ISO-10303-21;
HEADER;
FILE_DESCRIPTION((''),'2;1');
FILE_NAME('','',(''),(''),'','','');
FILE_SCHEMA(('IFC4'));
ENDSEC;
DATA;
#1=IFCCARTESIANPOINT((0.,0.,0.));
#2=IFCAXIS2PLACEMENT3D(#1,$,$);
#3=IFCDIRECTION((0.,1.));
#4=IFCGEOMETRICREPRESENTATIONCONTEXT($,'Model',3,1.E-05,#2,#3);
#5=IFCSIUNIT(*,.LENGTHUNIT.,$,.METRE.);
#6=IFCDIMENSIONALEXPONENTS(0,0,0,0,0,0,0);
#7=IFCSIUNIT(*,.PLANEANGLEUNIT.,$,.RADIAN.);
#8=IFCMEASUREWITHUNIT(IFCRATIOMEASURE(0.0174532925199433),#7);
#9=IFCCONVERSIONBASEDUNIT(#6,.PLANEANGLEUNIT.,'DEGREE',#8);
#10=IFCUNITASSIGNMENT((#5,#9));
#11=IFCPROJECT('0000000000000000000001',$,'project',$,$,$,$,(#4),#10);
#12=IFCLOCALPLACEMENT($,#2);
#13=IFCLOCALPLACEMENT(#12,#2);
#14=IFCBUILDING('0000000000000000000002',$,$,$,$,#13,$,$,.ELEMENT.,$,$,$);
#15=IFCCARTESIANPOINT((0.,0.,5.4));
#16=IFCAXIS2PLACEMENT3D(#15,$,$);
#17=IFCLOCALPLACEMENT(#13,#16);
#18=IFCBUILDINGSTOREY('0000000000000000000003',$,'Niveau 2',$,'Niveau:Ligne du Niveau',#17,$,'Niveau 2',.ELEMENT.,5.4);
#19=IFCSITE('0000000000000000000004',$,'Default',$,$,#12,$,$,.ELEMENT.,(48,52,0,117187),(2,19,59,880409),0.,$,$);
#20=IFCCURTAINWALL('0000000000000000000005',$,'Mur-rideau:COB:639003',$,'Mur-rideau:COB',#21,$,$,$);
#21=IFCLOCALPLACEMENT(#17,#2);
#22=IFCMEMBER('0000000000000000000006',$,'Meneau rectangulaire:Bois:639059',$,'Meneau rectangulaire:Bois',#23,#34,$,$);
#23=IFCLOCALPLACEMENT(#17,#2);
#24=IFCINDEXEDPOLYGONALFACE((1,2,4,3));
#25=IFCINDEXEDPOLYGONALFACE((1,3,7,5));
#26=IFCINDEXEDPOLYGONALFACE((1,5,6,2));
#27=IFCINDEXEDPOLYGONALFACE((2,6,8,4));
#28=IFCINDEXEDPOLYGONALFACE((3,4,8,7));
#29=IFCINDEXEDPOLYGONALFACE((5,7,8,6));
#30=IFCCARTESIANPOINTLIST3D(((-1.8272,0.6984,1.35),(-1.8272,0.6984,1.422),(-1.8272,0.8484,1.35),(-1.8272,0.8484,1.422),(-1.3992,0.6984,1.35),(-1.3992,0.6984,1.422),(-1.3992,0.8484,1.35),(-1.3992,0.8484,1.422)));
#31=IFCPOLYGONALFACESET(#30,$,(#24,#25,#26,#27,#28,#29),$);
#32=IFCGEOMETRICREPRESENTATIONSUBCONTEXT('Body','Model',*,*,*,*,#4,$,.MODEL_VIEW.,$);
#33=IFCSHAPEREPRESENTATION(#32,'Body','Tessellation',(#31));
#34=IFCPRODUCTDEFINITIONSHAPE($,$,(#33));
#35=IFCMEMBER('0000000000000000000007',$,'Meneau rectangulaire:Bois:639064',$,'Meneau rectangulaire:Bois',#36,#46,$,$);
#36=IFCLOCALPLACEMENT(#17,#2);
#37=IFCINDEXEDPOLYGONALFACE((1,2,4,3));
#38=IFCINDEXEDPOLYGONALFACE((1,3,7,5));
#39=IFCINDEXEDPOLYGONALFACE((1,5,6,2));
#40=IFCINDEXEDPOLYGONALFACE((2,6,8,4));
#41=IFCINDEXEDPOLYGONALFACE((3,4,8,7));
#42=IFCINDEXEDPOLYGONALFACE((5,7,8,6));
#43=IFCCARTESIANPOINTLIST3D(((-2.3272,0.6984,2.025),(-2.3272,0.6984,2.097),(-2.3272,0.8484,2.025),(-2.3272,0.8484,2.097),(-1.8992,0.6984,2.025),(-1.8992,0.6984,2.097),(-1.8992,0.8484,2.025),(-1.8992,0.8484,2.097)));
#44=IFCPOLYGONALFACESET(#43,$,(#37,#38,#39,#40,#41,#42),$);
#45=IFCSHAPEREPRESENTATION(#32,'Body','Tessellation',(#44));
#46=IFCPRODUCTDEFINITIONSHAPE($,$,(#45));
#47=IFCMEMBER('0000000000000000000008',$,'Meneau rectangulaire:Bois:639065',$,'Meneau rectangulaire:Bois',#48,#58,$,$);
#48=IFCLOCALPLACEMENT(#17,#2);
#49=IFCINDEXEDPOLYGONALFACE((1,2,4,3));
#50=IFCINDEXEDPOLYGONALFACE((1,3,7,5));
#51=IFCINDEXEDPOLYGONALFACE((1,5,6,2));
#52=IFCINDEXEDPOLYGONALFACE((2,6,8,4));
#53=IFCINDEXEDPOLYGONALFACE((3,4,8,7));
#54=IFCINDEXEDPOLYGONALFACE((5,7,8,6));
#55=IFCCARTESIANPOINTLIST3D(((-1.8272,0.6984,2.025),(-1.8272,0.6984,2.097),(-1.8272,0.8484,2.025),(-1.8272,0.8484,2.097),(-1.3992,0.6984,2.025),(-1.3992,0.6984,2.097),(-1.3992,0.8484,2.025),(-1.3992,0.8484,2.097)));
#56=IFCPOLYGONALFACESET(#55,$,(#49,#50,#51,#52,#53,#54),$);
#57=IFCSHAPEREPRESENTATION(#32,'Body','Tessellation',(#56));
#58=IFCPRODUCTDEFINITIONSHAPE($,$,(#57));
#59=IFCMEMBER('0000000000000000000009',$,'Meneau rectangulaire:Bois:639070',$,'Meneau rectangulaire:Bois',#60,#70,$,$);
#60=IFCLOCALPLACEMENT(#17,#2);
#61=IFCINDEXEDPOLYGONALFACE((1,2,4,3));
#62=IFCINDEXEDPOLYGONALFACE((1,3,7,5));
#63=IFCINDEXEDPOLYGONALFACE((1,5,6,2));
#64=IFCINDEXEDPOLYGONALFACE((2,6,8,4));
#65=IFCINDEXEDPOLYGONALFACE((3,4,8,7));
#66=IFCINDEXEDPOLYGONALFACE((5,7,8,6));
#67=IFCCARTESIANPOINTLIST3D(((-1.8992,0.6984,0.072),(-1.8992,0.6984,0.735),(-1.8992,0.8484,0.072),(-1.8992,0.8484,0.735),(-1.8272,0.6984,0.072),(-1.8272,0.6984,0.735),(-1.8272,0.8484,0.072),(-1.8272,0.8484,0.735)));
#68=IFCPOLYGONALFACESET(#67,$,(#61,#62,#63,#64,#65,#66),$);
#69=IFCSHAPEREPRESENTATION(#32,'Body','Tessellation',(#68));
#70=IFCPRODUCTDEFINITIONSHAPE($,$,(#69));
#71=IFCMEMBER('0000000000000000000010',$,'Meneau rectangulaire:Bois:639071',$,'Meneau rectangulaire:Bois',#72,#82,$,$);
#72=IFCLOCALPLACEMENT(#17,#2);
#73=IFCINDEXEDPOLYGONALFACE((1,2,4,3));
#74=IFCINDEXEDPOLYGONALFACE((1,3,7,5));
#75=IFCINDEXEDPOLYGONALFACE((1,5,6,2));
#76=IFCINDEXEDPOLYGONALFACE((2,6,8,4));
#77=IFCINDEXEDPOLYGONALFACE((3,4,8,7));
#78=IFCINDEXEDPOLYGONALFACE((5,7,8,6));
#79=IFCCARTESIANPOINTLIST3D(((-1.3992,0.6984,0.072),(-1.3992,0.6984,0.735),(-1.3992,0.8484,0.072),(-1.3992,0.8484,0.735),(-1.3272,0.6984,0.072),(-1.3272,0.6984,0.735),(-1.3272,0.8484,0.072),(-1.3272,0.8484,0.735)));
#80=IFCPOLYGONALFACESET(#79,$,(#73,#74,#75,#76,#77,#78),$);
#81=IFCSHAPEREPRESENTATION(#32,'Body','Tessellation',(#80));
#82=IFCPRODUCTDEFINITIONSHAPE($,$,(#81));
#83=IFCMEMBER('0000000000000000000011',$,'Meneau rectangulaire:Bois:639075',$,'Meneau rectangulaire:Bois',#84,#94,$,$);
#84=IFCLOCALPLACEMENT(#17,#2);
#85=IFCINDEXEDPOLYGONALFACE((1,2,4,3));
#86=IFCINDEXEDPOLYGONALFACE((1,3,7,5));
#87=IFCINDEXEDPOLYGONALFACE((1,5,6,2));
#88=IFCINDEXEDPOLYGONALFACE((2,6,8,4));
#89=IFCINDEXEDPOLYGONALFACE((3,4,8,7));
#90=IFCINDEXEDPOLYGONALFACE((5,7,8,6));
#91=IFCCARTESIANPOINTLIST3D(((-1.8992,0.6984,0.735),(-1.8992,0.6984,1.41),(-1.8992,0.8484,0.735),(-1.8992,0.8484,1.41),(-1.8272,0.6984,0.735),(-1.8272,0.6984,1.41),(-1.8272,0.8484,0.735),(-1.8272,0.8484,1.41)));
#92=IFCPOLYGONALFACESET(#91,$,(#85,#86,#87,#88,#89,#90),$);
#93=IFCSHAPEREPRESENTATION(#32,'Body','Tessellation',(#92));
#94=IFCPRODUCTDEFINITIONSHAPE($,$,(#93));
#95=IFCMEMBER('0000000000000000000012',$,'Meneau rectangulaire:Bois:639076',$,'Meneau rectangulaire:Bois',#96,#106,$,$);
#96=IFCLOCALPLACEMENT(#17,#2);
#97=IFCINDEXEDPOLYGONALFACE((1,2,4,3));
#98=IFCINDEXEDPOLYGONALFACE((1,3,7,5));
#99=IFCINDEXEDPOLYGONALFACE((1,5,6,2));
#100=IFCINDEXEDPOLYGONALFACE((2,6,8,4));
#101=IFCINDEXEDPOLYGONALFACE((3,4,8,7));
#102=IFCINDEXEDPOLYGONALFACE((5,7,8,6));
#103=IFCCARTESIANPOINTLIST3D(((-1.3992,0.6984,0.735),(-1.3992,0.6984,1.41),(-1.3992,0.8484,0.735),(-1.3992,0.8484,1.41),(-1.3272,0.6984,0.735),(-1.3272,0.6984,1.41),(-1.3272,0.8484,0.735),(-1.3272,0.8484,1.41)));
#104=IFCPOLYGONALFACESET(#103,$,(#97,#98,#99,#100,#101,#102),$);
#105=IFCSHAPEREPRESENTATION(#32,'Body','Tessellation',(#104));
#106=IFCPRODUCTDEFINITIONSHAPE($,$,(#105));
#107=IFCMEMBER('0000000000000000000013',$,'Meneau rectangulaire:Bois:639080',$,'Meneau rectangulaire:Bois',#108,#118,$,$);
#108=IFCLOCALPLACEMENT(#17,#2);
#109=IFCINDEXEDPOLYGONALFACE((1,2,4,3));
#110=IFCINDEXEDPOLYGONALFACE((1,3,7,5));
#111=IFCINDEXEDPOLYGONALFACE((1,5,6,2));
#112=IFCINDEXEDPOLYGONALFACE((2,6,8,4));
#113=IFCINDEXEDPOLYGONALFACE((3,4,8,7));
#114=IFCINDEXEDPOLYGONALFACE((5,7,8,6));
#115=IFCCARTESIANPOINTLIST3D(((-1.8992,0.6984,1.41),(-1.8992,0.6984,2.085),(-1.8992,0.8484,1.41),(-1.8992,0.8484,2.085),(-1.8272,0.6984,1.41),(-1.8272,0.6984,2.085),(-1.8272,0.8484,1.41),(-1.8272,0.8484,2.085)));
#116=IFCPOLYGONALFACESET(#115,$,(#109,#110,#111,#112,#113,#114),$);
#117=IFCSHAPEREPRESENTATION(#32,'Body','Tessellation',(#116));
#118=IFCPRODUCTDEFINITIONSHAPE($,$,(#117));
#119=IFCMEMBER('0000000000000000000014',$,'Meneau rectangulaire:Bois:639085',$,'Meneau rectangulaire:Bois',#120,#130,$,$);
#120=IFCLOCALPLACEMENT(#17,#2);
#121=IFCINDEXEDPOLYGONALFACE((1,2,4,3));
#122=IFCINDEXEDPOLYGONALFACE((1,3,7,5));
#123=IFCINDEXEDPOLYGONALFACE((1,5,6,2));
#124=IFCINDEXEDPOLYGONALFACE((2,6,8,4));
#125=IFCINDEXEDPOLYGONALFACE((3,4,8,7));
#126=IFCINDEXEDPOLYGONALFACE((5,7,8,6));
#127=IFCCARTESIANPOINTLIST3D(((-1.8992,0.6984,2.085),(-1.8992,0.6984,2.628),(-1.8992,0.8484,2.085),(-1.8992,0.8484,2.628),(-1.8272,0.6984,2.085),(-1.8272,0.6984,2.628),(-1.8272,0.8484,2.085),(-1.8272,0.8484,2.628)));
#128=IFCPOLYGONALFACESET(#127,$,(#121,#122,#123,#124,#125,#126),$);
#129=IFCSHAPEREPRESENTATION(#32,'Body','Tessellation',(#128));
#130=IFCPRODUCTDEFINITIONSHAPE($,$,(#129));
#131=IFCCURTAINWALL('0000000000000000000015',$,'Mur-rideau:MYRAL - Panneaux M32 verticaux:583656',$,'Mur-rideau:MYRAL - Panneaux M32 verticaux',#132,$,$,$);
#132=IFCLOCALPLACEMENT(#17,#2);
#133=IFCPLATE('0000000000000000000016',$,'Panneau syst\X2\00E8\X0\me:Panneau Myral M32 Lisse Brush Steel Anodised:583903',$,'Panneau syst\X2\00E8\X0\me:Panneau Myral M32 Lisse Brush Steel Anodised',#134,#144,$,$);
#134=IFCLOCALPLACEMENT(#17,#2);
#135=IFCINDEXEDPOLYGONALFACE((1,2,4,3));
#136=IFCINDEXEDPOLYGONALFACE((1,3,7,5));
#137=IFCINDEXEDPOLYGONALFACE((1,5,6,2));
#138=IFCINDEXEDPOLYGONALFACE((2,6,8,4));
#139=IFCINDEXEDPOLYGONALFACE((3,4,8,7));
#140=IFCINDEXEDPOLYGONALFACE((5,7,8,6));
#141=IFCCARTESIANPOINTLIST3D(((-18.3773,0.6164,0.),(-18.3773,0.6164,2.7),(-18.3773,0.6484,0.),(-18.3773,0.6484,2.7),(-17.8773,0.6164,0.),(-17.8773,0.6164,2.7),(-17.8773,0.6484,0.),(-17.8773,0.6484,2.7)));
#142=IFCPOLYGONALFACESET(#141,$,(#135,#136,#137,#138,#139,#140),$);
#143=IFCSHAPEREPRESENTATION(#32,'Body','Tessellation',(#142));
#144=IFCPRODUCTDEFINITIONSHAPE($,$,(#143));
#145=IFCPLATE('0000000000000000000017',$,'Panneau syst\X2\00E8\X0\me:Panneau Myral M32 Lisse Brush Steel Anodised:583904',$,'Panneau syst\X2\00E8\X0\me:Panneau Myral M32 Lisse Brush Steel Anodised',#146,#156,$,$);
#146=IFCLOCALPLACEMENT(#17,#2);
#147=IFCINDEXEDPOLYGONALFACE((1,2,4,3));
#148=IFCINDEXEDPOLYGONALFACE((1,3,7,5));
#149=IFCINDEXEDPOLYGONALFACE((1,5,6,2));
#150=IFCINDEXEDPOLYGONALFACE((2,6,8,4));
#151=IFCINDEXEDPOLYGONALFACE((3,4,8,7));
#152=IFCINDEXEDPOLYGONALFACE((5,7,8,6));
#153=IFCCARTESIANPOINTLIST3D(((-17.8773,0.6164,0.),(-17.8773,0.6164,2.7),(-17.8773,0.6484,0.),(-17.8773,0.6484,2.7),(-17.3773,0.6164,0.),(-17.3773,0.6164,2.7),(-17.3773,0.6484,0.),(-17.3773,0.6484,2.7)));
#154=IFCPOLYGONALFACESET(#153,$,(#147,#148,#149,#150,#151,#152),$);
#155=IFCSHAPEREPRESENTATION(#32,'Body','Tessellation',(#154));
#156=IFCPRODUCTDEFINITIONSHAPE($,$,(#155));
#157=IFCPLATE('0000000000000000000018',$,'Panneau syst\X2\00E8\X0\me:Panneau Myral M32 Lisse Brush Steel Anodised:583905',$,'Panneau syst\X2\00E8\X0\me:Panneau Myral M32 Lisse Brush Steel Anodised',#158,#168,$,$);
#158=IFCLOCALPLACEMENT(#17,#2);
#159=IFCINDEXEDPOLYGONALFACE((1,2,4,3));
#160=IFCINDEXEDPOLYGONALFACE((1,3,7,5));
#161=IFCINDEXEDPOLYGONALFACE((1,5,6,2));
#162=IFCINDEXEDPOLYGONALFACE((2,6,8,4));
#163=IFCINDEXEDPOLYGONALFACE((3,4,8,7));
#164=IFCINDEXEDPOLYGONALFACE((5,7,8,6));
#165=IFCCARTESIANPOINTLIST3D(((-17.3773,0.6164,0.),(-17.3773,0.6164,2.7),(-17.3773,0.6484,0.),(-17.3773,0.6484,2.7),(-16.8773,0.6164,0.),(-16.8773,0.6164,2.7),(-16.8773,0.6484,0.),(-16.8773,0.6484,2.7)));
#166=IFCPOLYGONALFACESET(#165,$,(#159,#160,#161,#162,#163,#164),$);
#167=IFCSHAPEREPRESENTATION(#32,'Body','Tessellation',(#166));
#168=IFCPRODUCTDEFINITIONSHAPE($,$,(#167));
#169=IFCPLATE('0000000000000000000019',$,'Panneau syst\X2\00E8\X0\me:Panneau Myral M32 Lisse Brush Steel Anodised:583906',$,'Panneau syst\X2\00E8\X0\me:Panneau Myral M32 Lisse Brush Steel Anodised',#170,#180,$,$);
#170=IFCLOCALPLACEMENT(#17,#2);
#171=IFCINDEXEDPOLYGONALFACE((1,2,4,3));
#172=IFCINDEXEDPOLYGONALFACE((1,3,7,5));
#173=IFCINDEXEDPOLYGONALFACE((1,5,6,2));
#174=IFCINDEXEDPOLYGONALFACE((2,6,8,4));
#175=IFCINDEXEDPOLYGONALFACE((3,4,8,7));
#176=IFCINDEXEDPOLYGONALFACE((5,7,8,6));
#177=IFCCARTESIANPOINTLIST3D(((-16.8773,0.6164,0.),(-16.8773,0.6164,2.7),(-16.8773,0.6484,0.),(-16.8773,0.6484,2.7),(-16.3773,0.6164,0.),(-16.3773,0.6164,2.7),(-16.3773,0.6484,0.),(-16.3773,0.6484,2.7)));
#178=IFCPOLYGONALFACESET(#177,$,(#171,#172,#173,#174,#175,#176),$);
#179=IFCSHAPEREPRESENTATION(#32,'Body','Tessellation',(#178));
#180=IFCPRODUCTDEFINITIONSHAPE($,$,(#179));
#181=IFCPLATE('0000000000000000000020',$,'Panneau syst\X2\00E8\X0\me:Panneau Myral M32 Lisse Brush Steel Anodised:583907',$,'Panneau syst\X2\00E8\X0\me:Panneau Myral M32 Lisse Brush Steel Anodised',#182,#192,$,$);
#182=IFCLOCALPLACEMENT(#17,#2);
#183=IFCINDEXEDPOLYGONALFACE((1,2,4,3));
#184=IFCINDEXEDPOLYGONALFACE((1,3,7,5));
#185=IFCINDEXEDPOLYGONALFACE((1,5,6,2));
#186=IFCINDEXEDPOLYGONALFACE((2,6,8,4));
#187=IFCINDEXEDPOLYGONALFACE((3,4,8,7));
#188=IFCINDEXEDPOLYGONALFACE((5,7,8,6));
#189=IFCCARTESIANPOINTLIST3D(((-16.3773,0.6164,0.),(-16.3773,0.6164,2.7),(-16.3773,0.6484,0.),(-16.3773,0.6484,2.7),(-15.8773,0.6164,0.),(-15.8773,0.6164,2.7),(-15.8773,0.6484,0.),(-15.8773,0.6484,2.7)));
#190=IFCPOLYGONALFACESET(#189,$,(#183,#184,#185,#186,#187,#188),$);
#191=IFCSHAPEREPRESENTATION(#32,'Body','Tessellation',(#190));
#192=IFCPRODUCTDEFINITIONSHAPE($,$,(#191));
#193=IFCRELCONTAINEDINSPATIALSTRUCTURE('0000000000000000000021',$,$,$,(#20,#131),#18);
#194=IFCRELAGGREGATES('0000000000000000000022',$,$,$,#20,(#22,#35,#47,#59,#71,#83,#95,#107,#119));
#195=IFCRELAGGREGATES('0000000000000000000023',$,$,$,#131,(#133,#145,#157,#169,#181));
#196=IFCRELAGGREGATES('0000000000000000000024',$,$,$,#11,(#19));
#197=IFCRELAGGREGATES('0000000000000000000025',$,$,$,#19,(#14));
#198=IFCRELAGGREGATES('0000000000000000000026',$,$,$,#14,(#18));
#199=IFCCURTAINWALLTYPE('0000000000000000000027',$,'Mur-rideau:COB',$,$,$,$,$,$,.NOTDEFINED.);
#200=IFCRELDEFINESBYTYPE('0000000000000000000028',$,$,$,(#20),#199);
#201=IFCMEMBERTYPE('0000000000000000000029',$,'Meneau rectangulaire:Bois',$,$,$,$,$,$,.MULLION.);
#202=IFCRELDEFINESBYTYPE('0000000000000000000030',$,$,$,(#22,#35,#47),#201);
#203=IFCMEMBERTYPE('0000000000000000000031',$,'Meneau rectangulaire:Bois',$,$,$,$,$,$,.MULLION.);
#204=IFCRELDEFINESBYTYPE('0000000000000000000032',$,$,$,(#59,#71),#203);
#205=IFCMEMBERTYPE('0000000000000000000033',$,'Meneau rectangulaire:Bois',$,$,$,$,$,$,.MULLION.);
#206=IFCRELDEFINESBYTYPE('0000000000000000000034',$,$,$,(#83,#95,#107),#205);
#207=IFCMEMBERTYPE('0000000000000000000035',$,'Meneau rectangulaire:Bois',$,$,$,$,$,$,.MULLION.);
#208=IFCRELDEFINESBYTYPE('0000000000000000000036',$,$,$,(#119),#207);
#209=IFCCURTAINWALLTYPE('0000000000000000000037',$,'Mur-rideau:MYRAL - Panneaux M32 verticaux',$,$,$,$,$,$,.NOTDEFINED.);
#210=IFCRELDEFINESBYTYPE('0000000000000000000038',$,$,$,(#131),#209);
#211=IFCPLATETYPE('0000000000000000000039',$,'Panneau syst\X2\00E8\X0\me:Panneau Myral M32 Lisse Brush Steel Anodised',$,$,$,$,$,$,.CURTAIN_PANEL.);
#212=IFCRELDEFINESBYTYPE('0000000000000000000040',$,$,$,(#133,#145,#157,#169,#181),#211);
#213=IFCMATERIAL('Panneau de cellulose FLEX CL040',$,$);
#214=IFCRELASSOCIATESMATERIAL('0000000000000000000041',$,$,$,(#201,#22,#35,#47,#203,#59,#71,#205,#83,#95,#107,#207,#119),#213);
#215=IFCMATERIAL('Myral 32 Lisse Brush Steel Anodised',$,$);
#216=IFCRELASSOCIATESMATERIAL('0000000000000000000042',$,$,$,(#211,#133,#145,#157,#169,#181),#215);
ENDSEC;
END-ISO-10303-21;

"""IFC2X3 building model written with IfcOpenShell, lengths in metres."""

from ifc_helpers import new_model, entity, si_unit, converted_unit, direction, frame, origin, origin_2d_with_axis, place, context, subcontext, project, spatial, rectangle, extrude, source, transform, mapped, material, type_object, type_shapes, element, aggregate, save


model = new_model("IFC2X3")

# Units and contexts
model_context = context("Model", 3, precision=1e-05, world=origin(), true_north=direction((0.0, 1.0)))
body_context = subcontext(model_context, "Body", "Model", "MODEL_VIEW")
ifc_project = project(units=[si_unit("LENGTHUNIT", "METRE"), converted_unit("PLANEANGLEUNIT", "DEGREE", entity("IfcRatioMeasure", 0.0174532925199433), si_unit("PLANEANGLEUNIT", "RADIAN"), dimensions=[0, 0, 0, 0, 0, 0, 0])], contexts=[model_context])

# Site, building, storey
site_placement = place(None, origin())
site = spatial("IfcSite", under=ifc_project, at=site_placement, Name="Default", CompositionType="ELEMENT", RefLatitude=(48, 52, 0, 117187), RefLongitude=(2, 19, 59, 880409), RefElevation=0.0)
building_placement = place(site_placement, origin())
building = spatial("IfcBuilding", under=site, at=building_placement, CompositionType="ELEMENT")
storey_placement = place(building_placement, frame((0.0, 0.0, 5.4)))
storey = spatial("IfcBuildingStorey", under=building, at=storey_placement, Name="Niveau 2", ObjectType="Niveau:Ligne du Niveau", LongName="Niveau 2", CompositionType="ELEMENT", Elevation=5.4)

# Curtain wall, members
curtain_wall_type_1 = type_object("IfcCurtainWallType", Name="Mur-rideau:COB", PredefinedType="NOTDEFINED")
curtain_wall_1_placement = place(storey_placement, frame((0.0, 0.0, -5.4)))
curtain_wall_1 = element("IfcCurtainWall", 1, at=curtain_wall_1_placement, inside=storey, type_object=curtain_wall_type_1, Name="Mur-rideau:COB:639003", ObjectType="Mur-rideau:COB")
ifc_material_1 = material(Name="Panneau de cellulose FLEX CL040")
member_type_1 = type_object("IfcMemberType", Name="Meneau rectangulaire:Bois", PredefinedType="MULLION", material=ifc_material_1)
shared_shape_1 = source(origin(), body_context, "Body", "SweptSolid", [
    extrude(rectangle(XDim=0.15, YDim=0.072, at=origin_2d_with_axis()), frame((-0.024, 0.0, -0.428), z_axis=(0.0, 0.0, 1.0), x_axis=(0.0, -1.0, 0.0)), (0.0, 0.0, 1.0), 0.428),
])
type_shapes(member_type_1, [shared_shape_1])
member_1_placement = place(storey_placement, frame((-1.3992, 0.7734, 1.41), z_axis=(1.0, 0.0, 0.0), x_axis=(0.0, 0.0, 1.0)))
member_1 = element("IfcMember", 2, at=member_1_placement, type_object=member_type_1, material=ifc_material_1, Name="Meneau rectangulaire:Bois:639059", ObjectType="Meneau rectangulaire:Bois", context=body_context, shape_type="MappedRepresentation", body=[
    mapped(shared_shape_1, transform((0.0, 0.0, 0.0), scale=1.0)),
])
member_2_placement = place(storey_placement, frame((-1.8992, 0.7734, 2.085), z_axis=(1.0, 0.0, 0.0), x_axis=(0.0, 0.0, 1.0)))
member_2 = element("IfcMember", 3, at=member_2_placement, type_object=member_type_1, material=ifc_material_1, Name="Meneau rectangulaire:Bois:639064", ObjectType="Meneau rectangulaire:Bois", context=body_context, shape_type="MappedRepresentation", body=[
    mapped(shared_shape_1, transform((0.0, 0.0, 0.0), scale=1.0)),
])
member_3_placement = place(storey_placement, frame((-1.3992, 0.7734, 2.085), z_axis=(1.0, 0.0, 0.0), x_axis=(0.0, 0.0, 1.0)))
member_3 = element("IfcMember", 4, at=member_3_placement, type_object=member_type_1, material=ifc_material_1, Name="Meneau rectangulaire:Bois:639065", ObjectType="Meneau rectangulaire:Bois", context=body_context, shape_type="MappedRepresentation", body=[
    mapped(shared_shape_1, transform((0.0, 0.0, 0.0), scale=1.0)),
])
member_type_2 = type_object("IfcMemberType", Name="Meneau rectangulaire:Bois", PredefinedType="MULLION", material=ifc_material_1)
shared_shape_2 = source(origin(), body_context, "Body", "SweptSolid", [
    extrude(rectangle(XDim=0.15, YDim=0.072, at=origin_2d_with_axis()), frame((-0.024, 0.0, -0.663), z_axis=(0.0, 0.0, 1.0), x_axis=(0.0, -1.0, 0.0)), (0.0, 0.0, 1.0), 0.663),
])
type_shapes(member_type_2, [shared_shape_2])
member_4_placement = place(storey_placement, frame((-1.8392, 0.7734, 0.072), z_axis=(0.0, 0.0, -1.0), x_axis=(1.0, 0.0, 0.0)))
member_4 = element("IfcMember", 5, at=member_4_placement, type_object=member_type_2, material=ifc_material_1, Name="Meneau rectangulaire:Bois:639070", ObjectType="Meneau rectangulaire:Bois", context=body_context, shape_type="MappedRepresentation", body=[
    mapped(shared_shape_2, transform((0.0, 0.0, 0.0), scale=1.0)),
])
member_5_placement = place(storey_placement, frame((-1.3392, 0.7734, 0.072), z_axis=(0.0, 0.0, -1.0), x_axis=(1.0, 0.0, 0.0)))
member_5 = element("IfcMember", 6, at=member_5_placement, type_object=member_type_2, material=ifc_material_1, Name="Meneau rectangulaire:Bois:639071", ObjectType="Meneau rectangulaire:Bois", context=body_context, shape_type="MappedRepresentation", body=[
    mapped(shared_shape_2, transform((0.0, 0.0, 0.0), scale=1.0)),
])
member_type_3 = type_object("IfcMemberType", Name="Meneau rectangulaire:Bois", PredefinedType="MULLION", material=ifc_material_1)
shared_shape_3 = source(origin(), body_context, "Body", "SweptSolid", [
    extrude(rectangle(XDim=0.15, YDim=0.072, at=origin_2d_with_axis()), frame((-0.024, 0.0, -0.675), z_axis=(0.0, 0.0, 1.0), x_axis=(0.0, -1.0, 0.0)), (0.0, 0.0, 1.0), 0.675),
])
type_shapes(member_type_3, [shared_shape_3])
member_6_placement = place(storey_placement, frame((-1.8392, 0.7734, 0.735), z_axis=(0.0, 0.0, -1.0), x_axis=(1.0, 0.0, 0.0)))
member_6 = element("IfcMember", 7, at=member_6_placement, type_object=member_type_3, material=ifc_material_1, Name="Meneau rectangulaire:Bois:639075", ObjectType="Meneau rectangulaire:Bois", context=body_context, shape_type="MappedRepresentation", body=[
    mapped(shared_shape_3, transform((0.0, 0.0, 0.0), scale=1.0)),
])
member_7_placement = place(storey_placement, frame((-1.3392, 0.7734, 0.735), z_axis=(0.0, 0.0, -1.0), x_axis=(1.0, 0.0, 0.0)))
member_7 = element("IfcMember", 8, at=member_7_placement, type_object=member_type_3, material=ifc_material_1, Name="Meneau rectangulaire:Bois:639076", ObjectType="Meneau rectangulaire:Bois", context=body_context, shape_type="MappedRepresentation", body=[
    mapped(shared_shape_3, transform((0.0, 0.0, 0.0), scale=1.0)),
])
member_8_placement = place(storey_placement, frame((-1.8392, 0.7734, 1.41), z_axis=(0.0, 0.0, -1.0), x_axis=(1.0, 0.0, 0.0)))
member_8 = element("IfcMember", 9, at=member_8_placement, type_object=member_type_3, material=ifc_material_1, Name="Meneau rectangulaire:Bois:639080", ObjectType="Meneau rectangulaire:Bois", context=body_context, shape_type="MappedRepresentation", body=[
    mapped(shared_shape_3, transform((0.0, 0.0, 0.0), scale=1.0)),
])
member_type_4 = type_object("IfcMemberType", Name="Meneau rectangulaire:Bois", PredefinedType="MULLION", material=ifc_material_1)
shared_shape_4 = source(origin(), body_context, "Body", "SweptSolid", [
    extrude(rectangle(XDim=0.15, YDim=0.072, at=origin_2d_with_axis()), frame((-0.024, 0.0, -0.543), z_axis=(0.0, 0.0, 1.0), x_axis=(0.0, -1.0, 0.0)), (0.0, 0.0, 1.0), 0.543),
])
type_shapes(member_type_4, [shared_shape_4])
member_9_placement = place(storey_placement, frame((-1.8392, 0.7734, 2.085), z_axis=(0.0, 0.0, -1.0), x_axis=(1.0, 0.0, 0.0)))
member_9 = element("IfcMember", 10, at=member_9_placement, type_object=member_type_4, material=ifc_material_1, Name="Meneau rectangulaire:Bois:639085", ObjectType="Meneau rectangulaire:Bois", context=body_context, shape_type="MappedRepresentation", body=[
    mapped(shared_shape_4, transform((0.0, 0.0, 0.0), scale=1.0)),
])
aggregate(curtain_wall_1, [member_1, member_2, member_3, member_4, member_5, member_6, member_7, member_8, member_9])

# Curtain wall, plates
curtain_wall_type_2 = type_object("IfcCurtainWallType", Name="Mur-rideau:MYRAL - Panneaux M32 verticaux", PredefinedType="NOTDEFINED")
curtain_wall_2_placement = place(storey_placement, frame((0.0, 0.0, -5.4)))
curtain_wall_2 = element("IfcCurtainWall", 11, at=curtain_wall_2_placement, inside=storey, type_object=curtain_wall_type_2, Name="Mur-rideau:MYRAL - Panneaux M32 verticaux:583656", ObjectType="Mur-rideau:MYRAL - Panneaux M32 verticaux")
ifc_material_2 = material(Name="Myral 32 Lisse Brush Steel Anodised")
plate_type = type_object("IfcPlateType", Name="Panneau système:Panneau Myral M32 Lisse Brush Steel Anodised", PredefinedType="CURTAIN_PANEL", material=ifc_material_2)
shared_shape_5 = source(origin(), body_context, "Body", "SweptSolid", [
    extrude(rectangle(XDim=0.032, YDim=0.5, at=origin_2d_with_axis()), frame((0.0, -0.016, 0.0), z_axis=(0.0, 0.0, 1.0), x_axis=(0.0, 1.0, 0.0)), (0.0, 0.0, 1.0), 2.7),
])
type_shapes(plate_type, [shared_shape_5])
plate_1_placement = place(curtain_wall_2_placement, frame((-18.1273, 0.6484, 5.4)))
plate_1 = element("IfcPlate", 12, at=plate_1_placement, type_object=plate_type, material=ifc_material_2, Name="Panneau système:Panneau Myral M32 Lisse Brush Steel Anodised:583903", ObjectType="Panneau système:Panneau Myral M32 Lisse Brush Steel Anodised", context=body_context, shape_type="MappedRepresentation", body=[
    mapped(shared_shape_5, transform((0.0, 0.0, 0.0), scale=1.0)),
])
plate_2_placement = place(curtain_wall_2_placement, frame((-17.6273, 0.6484, 5.4)))
plate_2 = element("IfcPlate", 13, at=plate_2_placement, type_object=plate_type, material=ifc_material_2, Name="Panneau système:Panneau Myral M32 Lisse Brush Steel Anodised:583904", ObjectType="Panneau système:Panneau Myral M32 Lisse Brush Steel Anodised", context=body_context, shape_type="MappedRepresentation", body=[
    mapped(shared_shape_5, transform((0.0, 0.0, 0.0), scale=1.0)),
])
plate_3_placement = place(curtain_wall_2_placement, frame((-17.1273, 0.6484, 5.4)))
plate_3 = element("IfcPlate", 14, at=plate_3_placement, type_object=plate_type, material=ifc_material_2, Name="Panneau système:Panneau Myral M32 Lisse Brush Steel Anodised:583905", ObjectType="Panneau système:Panneau Myral M32 Lisse Brush Steel Anodised", context=body_context, shape_type="MappedRepresentation", body=[
    mapped(shared_shape_5, transform((0.0, 0.0, 0.0), scale=1.0)),
])
plate_4_placement = place(curtain_wall_2_placement, frame((-16.6273, 0.6484, 5.4)))
plate_4 = element("IfcPlate", 15, at=plate_4_placement, type_object=plate_type, material=ifc_material_2, Name="Panneau système:Panneau Myral M32 Lisse Brush Steel Anodised:583906", ObjectType="Panneau système:Panneau Myral M32 Lisse Brush Steel Anodised", context=body_context, shape_type="MappedRepresentation", body=[
    mapped(shared_shape_5, transform((0.0, 0.0, 0.0), scale=1.0)),
])
plate_5_placement = place(curtain_wall_2_placement, frame((-16.1273, 0.6484, 5.4)))
plate_5 = element("IfcPlate", 16, at=plate_5_placement, type_object=plate_type, material=ifc_material_2, Name="Panneau système:Panneau Myral M32 Lisse Brush Steel Anodised:583907", ObjectType="Panneau système:Panneau Myral M32 Lisse Brush Steel Anodised", context=body_context, shape_type="MappedRepresentation", body=[
    mapped(shared_shape_5, transform((0.0, 0.0, 0.0), scale=1.0)),
])
aggregate(curtain_wall_2, [plate_1, plate_2, plate_3, plate_4, plate_5])

save(model, "model.ifc")
